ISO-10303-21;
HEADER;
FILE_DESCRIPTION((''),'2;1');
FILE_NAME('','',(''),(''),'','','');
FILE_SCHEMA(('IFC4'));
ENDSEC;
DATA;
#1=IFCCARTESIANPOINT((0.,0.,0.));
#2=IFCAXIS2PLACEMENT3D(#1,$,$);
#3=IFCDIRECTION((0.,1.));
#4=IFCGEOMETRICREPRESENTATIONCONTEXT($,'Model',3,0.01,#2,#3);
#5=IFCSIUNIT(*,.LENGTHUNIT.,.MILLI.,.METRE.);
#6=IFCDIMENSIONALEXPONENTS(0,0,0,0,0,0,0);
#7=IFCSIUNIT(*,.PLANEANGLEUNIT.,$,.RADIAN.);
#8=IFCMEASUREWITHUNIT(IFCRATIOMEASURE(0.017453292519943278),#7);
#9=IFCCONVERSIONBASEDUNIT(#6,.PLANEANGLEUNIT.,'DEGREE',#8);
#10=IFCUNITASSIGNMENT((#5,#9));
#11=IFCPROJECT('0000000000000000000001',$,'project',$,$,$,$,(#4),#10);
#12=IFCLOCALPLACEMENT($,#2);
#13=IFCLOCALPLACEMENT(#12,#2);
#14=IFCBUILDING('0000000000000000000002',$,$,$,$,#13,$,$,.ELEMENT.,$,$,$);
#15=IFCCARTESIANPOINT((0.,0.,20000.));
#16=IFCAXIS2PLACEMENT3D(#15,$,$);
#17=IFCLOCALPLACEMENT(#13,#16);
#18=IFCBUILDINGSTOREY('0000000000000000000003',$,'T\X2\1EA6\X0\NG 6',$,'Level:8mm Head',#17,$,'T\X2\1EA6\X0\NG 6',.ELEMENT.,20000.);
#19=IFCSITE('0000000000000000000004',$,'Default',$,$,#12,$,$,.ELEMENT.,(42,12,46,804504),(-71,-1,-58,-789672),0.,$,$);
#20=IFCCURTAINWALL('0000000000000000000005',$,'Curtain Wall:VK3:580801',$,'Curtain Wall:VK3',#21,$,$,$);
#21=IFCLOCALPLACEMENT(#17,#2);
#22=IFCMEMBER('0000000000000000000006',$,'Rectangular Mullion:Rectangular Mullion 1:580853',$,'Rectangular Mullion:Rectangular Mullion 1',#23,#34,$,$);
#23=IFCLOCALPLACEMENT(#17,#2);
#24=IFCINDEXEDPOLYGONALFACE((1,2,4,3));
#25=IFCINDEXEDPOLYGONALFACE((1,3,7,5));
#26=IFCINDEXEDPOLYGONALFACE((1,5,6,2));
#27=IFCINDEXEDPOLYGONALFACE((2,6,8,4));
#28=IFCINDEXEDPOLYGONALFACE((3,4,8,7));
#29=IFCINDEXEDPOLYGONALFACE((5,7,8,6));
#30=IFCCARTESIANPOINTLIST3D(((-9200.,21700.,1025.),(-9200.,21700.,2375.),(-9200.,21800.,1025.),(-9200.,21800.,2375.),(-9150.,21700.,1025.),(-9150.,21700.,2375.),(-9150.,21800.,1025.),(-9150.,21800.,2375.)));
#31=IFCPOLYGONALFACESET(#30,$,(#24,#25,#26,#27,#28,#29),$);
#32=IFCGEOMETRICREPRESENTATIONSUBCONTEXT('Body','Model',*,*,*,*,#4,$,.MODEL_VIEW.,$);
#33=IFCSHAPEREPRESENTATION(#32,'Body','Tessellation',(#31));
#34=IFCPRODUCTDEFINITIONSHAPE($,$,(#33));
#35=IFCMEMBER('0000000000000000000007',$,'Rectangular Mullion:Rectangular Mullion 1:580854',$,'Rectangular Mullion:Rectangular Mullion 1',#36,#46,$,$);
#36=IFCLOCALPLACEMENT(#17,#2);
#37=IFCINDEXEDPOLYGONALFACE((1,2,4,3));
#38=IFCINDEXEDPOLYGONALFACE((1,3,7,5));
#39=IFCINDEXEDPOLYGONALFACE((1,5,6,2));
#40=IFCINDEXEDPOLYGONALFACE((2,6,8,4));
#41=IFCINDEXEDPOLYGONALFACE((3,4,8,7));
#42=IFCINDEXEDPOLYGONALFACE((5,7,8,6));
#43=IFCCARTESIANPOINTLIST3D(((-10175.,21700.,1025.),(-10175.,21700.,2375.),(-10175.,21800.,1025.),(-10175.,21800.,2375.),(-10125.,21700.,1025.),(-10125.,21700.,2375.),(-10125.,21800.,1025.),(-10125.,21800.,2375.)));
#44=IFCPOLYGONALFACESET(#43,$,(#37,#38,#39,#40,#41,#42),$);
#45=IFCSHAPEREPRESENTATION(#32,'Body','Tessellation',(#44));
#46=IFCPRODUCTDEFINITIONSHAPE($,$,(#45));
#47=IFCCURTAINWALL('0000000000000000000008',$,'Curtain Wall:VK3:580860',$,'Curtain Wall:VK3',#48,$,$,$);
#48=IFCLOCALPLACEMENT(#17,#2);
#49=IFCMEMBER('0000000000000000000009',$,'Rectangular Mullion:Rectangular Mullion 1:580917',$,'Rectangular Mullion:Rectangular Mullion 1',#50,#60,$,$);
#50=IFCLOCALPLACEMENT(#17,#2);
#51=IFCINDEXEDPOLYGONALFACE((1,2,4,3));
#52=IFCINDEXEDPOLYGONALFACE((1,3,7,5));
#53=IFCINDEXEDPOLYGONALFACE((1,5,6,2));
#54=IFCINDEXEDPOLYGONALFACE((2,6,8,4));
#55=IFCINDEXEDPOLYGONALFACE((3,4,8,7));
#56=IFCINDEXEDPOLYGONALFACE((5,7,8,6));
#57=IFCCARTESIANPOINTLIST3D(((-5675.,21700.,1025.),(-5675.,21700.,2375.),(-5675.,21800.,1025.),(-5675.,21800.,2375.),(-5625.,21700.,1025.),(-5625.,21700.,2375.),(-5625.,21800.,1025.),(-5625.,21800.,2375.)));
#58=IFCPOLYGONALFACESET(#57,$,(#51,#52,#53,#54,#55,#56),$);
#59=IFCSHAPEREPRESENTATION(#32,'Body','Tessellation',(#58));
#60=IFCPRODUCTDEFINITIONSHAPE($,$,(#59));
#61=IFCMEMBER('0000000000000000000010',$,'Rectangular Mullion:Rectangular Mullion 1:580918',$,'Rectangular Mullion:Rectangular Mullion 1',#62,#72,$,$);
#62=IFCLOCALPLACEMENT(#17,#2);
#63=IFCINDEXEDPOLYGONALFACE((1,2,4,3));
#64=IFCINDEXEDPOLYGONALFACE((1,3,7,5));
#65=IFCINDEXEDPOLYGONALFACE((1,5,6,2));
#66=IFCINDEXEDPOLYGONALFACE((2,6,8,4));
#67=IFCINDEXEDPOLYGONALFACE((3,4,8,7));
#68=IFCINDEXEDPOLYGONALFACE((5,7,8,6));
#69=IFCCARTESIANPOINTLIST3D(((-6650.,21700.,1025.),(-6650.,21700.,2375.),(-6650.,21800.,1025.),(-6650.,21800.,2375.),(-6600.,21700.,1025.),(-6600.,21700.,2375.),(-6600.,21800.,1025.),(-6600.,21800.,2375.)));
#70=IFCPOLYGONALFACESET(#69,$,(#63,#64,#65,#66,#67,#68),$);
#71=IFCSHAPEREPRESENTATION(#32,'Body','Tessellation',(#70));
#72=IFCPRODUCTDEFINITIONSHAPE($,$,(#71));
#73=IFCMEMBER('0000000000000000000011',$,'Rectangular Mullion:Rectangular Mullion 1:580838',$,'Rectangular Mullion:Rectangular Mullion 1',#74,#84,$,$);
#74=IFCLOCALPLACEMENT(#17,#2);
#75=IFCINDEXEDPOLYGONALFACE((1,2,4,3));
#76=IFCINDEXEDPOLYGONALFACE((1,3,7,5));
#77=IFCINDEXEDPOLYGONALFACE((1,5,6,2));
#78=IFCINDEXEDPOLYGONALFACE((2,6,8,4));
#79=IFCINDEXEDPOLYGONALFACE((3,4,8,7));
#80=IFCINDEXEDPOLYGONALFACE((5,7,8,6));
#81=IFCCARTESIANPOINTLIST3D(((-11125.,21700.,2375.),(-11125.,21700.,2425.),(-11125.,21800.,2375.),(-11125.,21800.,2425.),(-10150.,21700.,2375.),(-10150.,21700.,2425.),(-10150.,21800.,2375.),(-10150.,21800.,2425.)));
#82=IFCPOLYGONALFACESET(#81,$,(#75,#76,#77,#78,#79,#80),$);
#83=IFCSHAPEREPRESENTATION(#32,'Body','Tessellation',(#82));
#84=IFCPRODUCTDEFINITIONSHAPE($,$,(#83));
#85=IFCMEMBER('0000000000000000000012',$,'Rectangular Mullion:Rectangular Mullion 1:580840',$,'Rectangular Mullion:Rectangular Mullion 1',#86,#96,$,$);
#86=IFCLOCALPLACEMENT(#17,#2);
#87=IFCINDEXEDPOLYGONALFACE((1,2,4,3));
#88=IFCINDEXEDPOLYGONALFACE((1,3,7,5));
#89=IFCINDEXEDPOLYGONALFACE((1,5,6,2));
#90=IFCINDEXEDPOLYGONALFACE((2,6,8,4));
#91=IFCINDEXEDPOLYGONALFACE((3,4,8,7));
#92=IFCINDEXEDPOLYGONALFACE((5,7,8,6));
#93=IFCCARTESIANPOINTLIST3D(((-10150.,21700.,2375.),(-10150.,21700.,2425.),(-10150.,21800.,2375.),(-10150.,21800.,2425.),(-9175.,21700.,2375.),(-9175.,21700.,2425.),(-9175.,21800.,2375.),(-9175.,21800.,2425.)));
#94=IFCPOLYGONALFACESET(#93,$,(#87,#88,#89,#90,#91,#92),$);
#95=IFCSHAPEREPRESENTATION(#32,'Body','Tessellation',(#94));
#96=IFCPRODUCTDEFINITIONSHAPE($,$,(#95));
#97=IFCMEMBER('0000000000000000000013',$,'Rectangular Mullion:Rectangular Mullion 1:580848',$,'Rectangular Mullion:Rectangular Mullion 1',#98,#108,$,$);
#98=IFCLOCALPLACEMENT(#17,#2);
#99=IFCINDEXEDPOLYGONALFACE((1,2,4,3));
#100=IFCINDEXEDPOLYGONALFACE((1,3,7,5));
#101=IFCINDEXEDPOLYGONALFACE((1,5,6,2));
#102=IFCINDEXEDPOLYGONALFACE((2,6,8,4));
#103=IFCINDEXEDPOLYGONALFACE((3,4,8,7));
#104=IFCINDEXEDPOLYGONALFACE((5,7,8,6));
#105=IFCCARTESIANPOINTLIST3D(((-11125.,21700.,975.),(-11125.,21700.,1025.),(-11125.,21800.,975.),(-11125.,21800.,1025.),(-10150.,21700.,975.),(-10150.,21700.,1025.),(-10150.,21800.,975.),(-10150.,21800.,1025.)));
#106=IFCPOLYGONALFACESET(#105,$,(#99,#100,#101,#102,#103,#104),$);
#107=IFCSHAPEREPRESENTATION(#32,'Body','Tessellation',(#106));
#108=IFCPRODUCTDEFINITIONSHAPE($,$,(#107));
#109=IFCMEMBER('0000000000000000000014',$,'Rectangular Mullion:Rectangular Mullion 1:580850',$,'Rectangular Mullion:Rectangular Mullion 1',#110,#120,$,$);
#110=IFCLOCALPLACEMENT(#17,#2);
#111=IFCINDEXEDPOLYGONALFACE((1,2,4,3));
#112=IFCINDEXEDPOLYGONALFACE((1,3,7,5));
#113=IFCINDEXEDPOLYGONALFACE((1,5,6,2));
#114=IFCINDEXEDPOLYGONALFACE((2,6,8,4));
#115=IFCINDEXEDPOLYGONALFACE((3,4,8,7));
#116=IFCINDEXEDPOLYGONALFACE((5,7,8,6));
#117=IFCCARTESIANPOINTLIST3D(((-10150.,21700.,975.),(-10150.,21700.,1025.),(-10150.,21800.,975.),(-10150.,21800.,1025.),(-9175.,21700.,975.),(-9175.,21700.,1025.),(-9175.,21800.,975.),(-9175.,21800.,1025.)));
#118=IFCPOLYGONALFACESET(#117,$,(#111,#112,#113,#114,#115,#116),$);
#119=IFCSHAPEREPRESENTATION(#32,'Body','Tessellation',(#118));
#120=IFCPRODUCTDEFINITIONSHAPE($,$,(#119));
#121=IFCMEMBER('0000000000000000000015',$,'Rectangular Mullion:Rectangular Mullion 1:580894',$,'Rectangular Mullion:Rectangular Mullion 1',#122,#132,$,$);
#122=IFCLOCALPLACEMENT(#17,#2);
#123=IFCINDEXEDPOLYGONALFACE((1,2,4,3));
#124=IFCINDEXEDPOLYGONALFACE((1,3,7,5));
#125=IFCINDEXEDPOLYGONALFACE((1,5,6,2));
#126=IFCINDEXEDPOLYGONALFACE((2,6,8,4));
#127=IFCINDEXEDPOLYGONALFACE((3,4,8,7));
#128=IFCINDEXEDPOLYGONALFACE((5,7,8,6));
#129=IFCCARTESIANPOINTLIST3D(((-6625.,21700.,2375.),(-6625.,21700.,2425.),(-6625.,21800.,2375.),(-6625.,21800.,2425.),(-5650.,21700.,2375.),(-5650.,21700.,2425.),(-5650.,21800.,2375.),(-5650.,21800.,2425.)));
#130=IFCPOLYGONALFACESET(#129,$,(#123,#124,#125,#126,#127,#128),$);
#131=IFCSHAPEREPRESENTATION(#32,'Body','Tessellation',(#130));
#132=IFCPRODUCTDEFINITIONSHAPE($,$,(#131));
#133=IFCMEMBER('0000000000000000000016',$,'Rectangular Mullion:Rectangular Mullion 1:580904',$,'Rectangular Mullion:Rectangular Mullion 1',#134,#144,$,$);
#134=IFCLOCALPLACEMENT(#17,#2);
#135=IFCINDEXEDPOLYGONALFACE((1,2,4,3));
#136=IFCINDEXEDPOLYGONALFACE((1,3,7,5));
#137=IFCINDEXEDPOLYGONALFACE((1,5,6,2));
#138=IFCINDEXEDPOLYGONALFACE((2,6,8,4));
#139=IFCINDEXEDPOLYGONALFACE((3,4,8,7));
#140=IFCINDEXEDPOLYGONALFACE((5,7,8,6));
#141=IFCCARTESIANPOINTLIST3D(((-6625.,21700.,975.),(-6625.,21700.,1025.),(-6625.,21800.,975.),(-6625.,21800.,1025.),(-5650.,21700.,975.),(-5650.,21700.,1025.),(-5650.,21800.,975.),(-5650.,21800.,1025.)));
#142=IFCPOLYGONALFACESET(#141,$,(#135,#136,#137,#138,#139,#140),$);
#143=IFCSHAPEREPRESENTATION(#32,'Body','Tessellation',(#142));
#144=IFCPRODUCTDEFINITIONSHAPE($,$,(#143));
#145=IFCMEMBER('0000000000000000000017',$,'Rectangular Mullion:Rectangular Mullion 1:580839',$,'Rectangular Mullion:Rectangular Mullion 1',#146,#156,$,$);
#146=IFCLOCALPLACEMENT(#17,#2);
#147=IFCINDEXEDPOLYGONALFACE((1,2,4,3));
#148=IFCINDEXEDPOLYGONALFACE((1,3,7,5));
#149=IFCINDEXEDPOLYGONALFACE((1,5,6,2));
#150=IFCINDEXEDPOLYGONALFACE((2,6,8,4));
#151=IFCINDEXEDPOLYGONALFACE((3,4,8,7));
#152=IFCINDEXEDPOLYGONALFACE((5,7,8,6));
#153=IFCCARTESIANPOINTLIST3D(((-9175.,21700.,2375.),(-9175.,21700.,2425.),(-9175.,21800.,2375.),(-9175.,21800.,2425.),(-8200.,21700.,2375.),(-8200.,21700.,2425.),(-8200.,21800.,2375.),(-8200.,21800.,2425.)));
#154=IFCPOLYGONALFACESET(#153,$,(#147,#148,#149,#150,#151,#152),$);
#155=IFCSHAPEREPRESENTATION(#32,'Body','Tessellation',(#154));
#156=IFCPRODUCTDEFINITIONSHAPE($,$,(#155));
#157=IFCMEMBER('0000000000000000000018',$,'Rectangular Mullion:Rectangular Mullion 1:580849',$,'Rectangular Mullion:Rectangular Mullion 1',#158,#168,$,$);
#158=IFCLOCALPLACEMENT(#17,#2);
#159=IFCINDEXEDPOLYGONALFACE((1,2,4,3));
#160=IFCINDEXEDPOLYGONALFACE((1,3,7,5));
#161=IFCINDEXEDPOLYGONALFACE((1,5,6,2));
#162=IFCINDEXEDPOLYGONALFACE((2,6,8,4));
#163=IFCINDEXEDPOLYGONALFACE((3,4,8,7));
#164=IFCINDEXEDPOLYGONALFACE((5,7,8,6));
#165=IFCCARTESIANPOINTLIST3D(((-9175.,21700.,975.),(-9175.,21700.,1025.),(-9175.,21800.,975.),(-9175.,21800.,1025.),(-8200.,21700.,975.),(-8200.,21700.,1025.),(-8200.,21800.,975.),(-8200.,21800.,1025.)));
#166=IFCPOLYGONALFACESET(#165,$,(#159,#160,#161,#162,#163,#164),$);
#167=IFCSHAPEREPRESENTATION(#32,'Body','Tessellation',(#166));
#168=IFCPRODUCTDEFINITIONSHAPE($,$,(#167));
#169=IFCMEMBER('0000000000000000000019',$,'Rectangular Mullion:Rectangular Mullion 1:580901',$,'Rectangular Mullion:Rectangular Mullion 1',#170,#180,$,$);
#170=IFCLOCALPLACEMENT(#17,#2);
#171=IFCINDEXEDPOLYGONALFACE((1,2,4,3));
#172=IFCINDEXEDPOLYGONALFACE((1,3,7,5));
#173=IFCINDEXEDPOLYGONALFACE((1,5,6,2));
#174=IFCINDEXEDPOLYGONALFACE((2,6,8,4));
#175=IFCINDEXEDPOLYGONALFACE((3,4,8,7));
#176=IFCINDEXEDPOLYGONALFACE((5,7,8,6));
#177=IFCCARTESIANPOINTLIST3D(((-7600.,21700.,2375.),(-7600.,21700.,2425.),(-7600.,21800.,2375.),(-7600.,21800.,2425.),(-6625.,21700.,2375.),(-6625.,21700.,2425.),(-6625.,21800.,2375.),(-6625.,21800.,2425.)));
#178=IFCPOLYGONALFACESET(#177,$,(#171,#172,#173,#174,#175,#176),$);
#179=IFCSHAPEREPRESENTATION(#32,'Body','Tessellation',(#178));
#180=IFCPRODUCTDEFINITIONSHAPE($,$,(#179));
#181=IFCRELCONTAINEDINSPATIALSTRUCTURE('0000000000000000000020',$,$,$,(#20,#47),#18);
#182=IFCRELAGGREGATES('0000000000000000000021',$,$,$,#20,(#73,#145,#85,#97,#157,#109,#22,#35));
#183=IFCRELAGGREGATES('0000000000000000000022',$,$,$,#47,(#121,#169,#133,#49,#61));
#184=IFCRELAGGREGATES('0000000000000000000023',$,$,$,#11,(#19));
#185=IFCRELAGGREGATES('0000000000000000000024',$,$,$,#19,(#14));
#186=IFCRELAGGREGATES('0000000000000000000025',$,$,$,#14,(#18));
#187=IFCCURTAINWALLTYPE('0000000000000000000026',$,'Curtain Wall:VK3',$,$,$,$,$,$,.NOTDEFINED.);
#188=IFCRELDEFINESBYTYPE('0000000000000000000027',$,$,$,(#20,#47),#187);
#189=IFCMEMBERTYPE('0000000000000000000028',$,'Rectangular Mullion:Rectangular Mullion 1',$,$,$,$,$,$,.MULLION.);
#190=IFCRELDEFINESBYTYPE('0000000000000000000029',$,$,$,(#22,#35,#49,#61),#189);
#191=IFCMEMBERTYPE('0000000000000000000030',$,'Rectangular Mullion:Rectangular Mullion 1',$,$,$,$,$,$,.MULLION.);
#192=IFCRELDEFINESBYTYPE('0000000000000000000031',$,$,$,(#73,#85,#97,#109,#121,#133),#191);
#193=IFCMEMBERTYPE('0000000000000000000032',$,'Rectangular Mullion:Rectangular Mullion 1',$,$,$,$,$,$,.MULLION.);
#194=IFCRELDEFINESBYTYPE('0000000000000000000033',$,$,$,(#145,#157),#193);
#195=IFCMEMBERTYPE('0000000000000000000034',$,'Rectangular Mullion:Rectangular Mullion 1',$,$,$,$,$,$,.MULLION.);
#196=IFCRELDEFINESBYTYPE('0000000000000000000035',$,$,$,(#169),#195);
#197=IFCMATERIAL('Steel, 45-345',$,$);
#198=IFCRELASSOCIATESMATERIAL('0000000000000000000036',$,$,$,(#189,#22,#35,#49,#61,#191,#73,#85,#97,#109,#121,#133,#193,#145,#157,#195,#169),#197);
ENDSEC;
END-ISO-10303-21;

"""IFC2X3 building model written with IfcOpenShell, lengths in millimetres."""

from ifc_helpers import new_model, entity, si_unit, converted_unit, direction, frame, origin, origin_2d_with_axis, place, context, subcontext, project, spatial, rectangle, extrude, source, transform, mapped, material, type_object, type_shapes, element, aggregate, save


model = new_model("IFC2X3")

# Units and contexts
model_context = context("Model", 3, precision=0.01, world=origin(), true_north=direction((0.0, 1.0)))
body_context = subcontext(model_context, "Body", "Model", "MODEL_VIEW")
ifc_project = project(units=[si_unit("LENGTHUNIT", "METRE", prefix="MILLI"), converted_unit("PLANEANGLEUNIT", "DEGREE", entity("IfcRatioMeasure", 0.017453292519943278), si_unit("PLANEANGLEUNIT", "RADIAN"), dimensions=[0, 0, 0, 0, 0, 0, 0])], contexts=[model_context])

# Site, building, storey
site_placement = place(None, origin())
site = spatial("IfcSite", under=ifc_project, at=site_placement, Name="Default", CompositionType="ELEMENT", RefLatitude=(42, 12, 46, 804504), RefLongitude=(-71, -1, -58, -789672), RefElevation=0.0)
building_placement = place(site_placement, origin())
building = spatial("IfcBuilding", under=site, at=building_placement, CompositionType="ELEMENT")
storey_placement = place(building_placement, frame((0.0, 0.0, 20000.0)))
storey = spatial("IfcBuildingStorey", under=building, at=storey_placement, Name="TẦNG 6", ObjectType="Level:8mm Head", LongName="TẦNG 6", CompositionType="ELEMENT", Elevation=20000.0)

# Curtain walls, members
curtain_wall_type_1 = type_object("IfcCurtainWallType", Name="Curtain Wall:VK3", PredefinedType="NOTDEFINED")
curtain_wall_1_placement = place(storey_placement, frame((0.0, 0.0, -20000.0)))
curtain_wall_1 = element("IfcCurtainWall", 1, at=curtain_wall_1_placement, inside=storey, type_object=curtain_wall_type_1, Name="Curtain Wall:VK3:580801", ObjectType="Curtain Wall:VK3")
ifc_material_1 = material(Name="Steel, 45-345")
member_type_1 = type_object("IfcMemberType", Name="Rectangular Mullion:Rectangular Mullion 1", PredefinedType="MULLION", material=ifc_material_1)
shared_shape_1 = source(origin(), body_context, "Body", "SweptSolid", [
    extrude(rectangle(XDim=100.0, YDim=50.0, at=origin_2d_with_axis()), frame((0.0, -50.0, -1350.0), z_axis=(0.0, 0.0, 1.0), x_axis=(0.0, -1.0, 0.0)), (0.0, 0.0, 1.0), 1350.0),
])
type_shapes(member_type_1, [shared_shape_1])
member_1_placement = place(curtain_wall_1_placement, frame((-9175.0, 21700.0, 21025.0), z_axis=(0.0, 0.0, -1.0), x_axis=(1.0, 0.0, 0.0)))
member_1 = element("IfcMember", 2, at=member_1_placement, type_object=member_type_1, material=ifc_material_1, Name="Rectangular Mullion:Rectangular Mullion 1:580853", ObjectType="Rectangular Mullion:Rectangular Mullion 1", context=body_context, shape_type="MappedRepresentation", body=[
    mapped(shared_shape_1, transform((0.0, 0.0, 0.0), scale=1.0)),
])
member_2_placement = place(curtain_wall_1_placement, frame((-10150.0, 21700.0, 21025.0), z_axis=(0.0, 0.0, -1.0), x_axis=(1.0, 0.0, 0.0)))
member_2 = element("IfcMember", 3, at=member_2_placement, type_object=member_type_1, material=ifc_material_1, Name="Rectangular Mullion:Rectangular Mullion 1:580854", ObjectType="Rectangular Mullion:Rectangular Mullion 1", context=body_context, shape_type="MappedRepresentation", body=[
    mapped(shared_shape_1, transform((0.0, 0.0, 0.0), scale=1.0)),
])
curtain_wall_2_placement = place(storey_placement, frame((0.0, 0.0, -20000.0)))
curtain_wall_2 = element("IfcCurtainWall", 4, at=curtain_wall_2_placement, inside=storey, type_object=curtain_wall_type_1, Name="Curtain Wall:VK3:580860", ObjectType="Curtain Wall:VK3")
member_3_placement = place(curtain_wall_2_placement, frame((-5650.0, 21700.0, 21025.0), z_axis=(0.0, 0.0, -1.0), x_axis=(1.0, 0.0, 0.0)))
member_3 = element("IfcMember", 5, at=member_3_placement, type_object=member_type_1, material=ifc_material_1, Name="Rectangular Mullion:Rectangular Mullion 1:580917", ObjectType="Rectangular Mullion:Rectangular Mullion 1", context=body_context, shape_type="MappedRepresentation", body=[
    mapped(shared_shape_1, transform((0.0, 0.0, 0.0), scale=1.0)),
])
member_4_placement = place(curtain_wall_2_placement, frame((-6625.0, 21700.0, 21025.0), z_axis=(0.0, 0.0, -1.0), x_axis=(1.0, 0.0, 0.0)))
member_4 = element("IfcMember", 6, at=member_4_placement, type_object=member_type_1, material=ifc_material_1, Name="Rectangular Mullion:Rectangular Mullion 1:580918", ObjectType="Rectangular Mullion:Rectangular Mullion 1", context=body_context, shape_type="MappedRepresentation", body=[
    mapped(shared_shape_1, transform((0.0, 0.0, 0.0), scale=1.0)),
])

# Members
member_type_2 = type_object("IfcMemberType", Name="Rectangular Mullion:Rectangular Mullion 1", PredefinedType="MULLION", material=ifc_material_1)
shared_shape_2 = source(origin(), body_context, "Body", "SweptSolid", [
    extrude(rectangle(XDim=100.0, YDim=50.0, at=origin_2d_with_axis()), frame((0.0, -50.0, -975.0), z_axis=(0.0, 0.0, 1.0), x_axis=(0.0, -1.0, 0.0)), (0.0, 0.0, 1.0), 975.0),
])
type_shapes(member_type_2, [shared_shape_2])
member_5_placement = place(curtain_wall_1_placement, frame((-10150.0, 21700.0, 22400.0), z_axis=(1.0, 0.0, 0.0), x_axis=(0.0, 0.0, 1.0)))
member_5 = element("IfcMember", 7, at=member_5_placement, type_object=member_type_2, material=ifc_material_1, Name="Rectangular Mullion:Rectangular Mullion 1:580838", ObjectType="Rectangular Mullion:Rectangular Mullion 1", context=body_context, shape_type="MappedRepresentation", body=[
    mapped(shared_shape_2, transform((0.0, 0.0, 0.0), scale=1.0)),
])
member_6_placement = place(curtain_wall_1_placement, frame((-9175.0, 21700.0, 22400.0), z_axis=(1.0, 0.0, 0.0), x_axis=(0.0, 0.0, 1.0)))
member_6 = element("IfcMember", 8, at=member_6_placement, type_object=member_type_2, material=ifc_material_1, Name="Rectangular Mullion:Rectangular Mullion 1:580840", ObjectType="Rectangular Mullion:Rectangular Mullion 1", context=body_context, shape_type="MappedRepresentation", body=[
    mapped(shared_shape_2, transform((0.0, 0.0, 0.0), scale=1.0)),
])
member_7_placement = place(curtain_wall_1_placement, frame((-10150.0, 21700.0, 21000.0), z_axis=(1.0, 0.0, 0.0), x_axis=(0.0, 0.0, 1.0)))
member_7 = element("IfcMember", 9, at=member_7_placement, type_object=member_type_2, material=ifc_material_1, Name="Rectangular Mullion:Rectangular Mullion 1:580848", ObjectType="Rectangular Mullion:Rectangular Mullion 1", context=body_context, shape_type="MappedRepresentation", body=[
    mapped(shared_shape_2, transform((0.0, 0.0, 0.0), scale=1.0)),
])
member_8_placement = place(curtain_wall_1_placement, frame((-9175.0, 21700.0, 21000.0), z_axis=(1.0, 0.0, 0.0), x_axis=(0.0, 0.0, 1.0)))
member_8 = element("IfcMember", 10, at=member_8_placement, type_object=member_type_2, material=ifc_material_1, Name="Rectangular Mullion:Rectangular Mullion 1:580850", ObjectType="Rectangular Mullion:Rectangular Mullion 1", context=body_context, shape_type="MappedRepresentation", body=[
    mapped(shared_shape_2, transform((0.0, 0.0, 0.0), scale=1.0)),
])
member_9_placement = place(curtain_wall_2_placement, frame((-5650.0, 21700.0, 22400.0), z_axis=(1.0, 0.0, 0.0), x_axis=(0.0, 0.0, 1.0)))
member_9 = element("IfcMember", 11, at=member_9_placement, type_object=member_type_2, material=ifc_material_1, Name="Rectangular Mullion:Rectangular Mullion 1:580894", ObjectType="Rectangular Mullion:Rectangular Mullion 1", context=body_context, shape_type="MappedRepresentation", body=[
    mapped(shared_shape_2, transform((0.0, 0.0, 0.0), scale=1.0)),
])
member_10_placement = place(curtain_wall_2_placement, frame((-5650.0, 21700.0, 21000.0), z_axis=(1.0, 0.0, 0.0), x_axis=(0.0, 0.0, 1.0)))
member_10 = element("IfcMember", 12, at=member_10_placement, type_object=member_type_2, material=ifc_material_1, Name="Rectangular Mullion:Rectangular Mullion 1:580904", ObjectType="Rectangular Mullion:Rectangular Mullion 1", context=body_context, shape_type="MappedRepresentation", body=[
    mapped(shared_shape_2, transform((0.0, 0.0, 0.0), scale=1.0)),
])
member_type_3 = type_object("IfcMemberType", Name="Rectangular Mullion:Rectangular Mullion 1", PredefinedType="MULLION", material=ifc_material_1)
shared_shape_3 = source(origin(), body_context, "Body", "SweptSolid", [
    extrude(rectangle(XDim=100.0, YDim=50.0, at=origin_2d_with_axis()), frame((0.0, -50.0, -975.0), z_axis=(0.0, 0.0, 1.0), x_axis=(0.0, -1.0, 0.0)), (0.0, 0.0, 1.0), 975.0),
])
type_shapes(member_type_3, [shared_shape_3])
member_11_placement = place(curtain_wall_1_placement, frame((-8200.0, 21700.0, 22400.0), z_axis=(1.0, 0.0, 0.0), x_axis=(0.0, 0.0, 1.0)))
member_11 = element("IfcMember", 13, at=member_11_placement, type_object=member_type_3, material=ifc_material_1, Name="Rectangular Mullion:Rectangular Mullion 1:580839", ObjectType="Rectangular Mullion:Rectangular Mullion 1", context=body_context, shape_type="MappedRepresentation", body=[
    mapped(shared_shape_3, transform((0.0, 0.0, 0.0), scale=1.0)),
])
member_12_placement = place(curtain_wall_1_placement, frame((-8200.0, 21700.0, 21000.0), z_axis=(1.0, 0.0, 0.0), x_axis=(0.0, 0.0, 1.0)))
member_12 = element("IfcMember", 14, at=member_12_placement, type_object=member_type_3, material=ifc_material_1, Name="Rectangular Mullion:Rectangular Mullion 1:580849", ObjectType="Rectangular Mullion:Rectangular Mullion 1", context=body_context, shape_type="MappedRepresentation", body=[
    mapped(shared_shape_3, transform((0.0, 0.0, 0.0), scale=1.0)),
])
member_type_4 = type_object("IfcMemberType", Name="Rectangular Mullion:Rectangular Mullion 1", PredefinedType="MULLION", material=ifc_material_1)
shared_shape_4 = source(origin(), body_context, "Body", "SweptSolid", [
    extrude(rectangle(XDim=100.0, YDim=50.0, at=origin_2d_with_axis()), frame((0.0, -50.0, -975.0), z_axis=(0.0, 0.0, 1.0), x_axis=(0.0, -1.0, 0.0)), (0.0, 0.0, 1.0), 975.0),
])
type_shapes(member_type_4, [shared_shape_4])
member_13_placement = place(curtain_wall_2_placement, frame((-6625.0, 21700.0, 22400.0), z_axis=(1.0, 0.0, 0.0), x_axis=(0.0, 0.0, 1.0)))
member_13 = element("IfcMember", 15, at=member_13_placement, type_object=member_type_4, material=ifc_material_1, Name="Rectangular Mullion:Rectangular Mullion 1:580901", ObjectType="Rectangular Mullion:Rectangular Mullion 1", context=body_context, shape_type="MappedRepresentation", body=[
    mapped(shared_shape_4, transform((0.0, 0.0, 0.0), scale=1.0)),
])

aggregate(curtain_wall_1, [member_5, member_11, member_6, member_7, member_12, member_8, member_1, member_2])
aggregate(curtain_wall_2, [member_9, member_13, member_10, member_3, member_4])

save(model, "model.ifc")
